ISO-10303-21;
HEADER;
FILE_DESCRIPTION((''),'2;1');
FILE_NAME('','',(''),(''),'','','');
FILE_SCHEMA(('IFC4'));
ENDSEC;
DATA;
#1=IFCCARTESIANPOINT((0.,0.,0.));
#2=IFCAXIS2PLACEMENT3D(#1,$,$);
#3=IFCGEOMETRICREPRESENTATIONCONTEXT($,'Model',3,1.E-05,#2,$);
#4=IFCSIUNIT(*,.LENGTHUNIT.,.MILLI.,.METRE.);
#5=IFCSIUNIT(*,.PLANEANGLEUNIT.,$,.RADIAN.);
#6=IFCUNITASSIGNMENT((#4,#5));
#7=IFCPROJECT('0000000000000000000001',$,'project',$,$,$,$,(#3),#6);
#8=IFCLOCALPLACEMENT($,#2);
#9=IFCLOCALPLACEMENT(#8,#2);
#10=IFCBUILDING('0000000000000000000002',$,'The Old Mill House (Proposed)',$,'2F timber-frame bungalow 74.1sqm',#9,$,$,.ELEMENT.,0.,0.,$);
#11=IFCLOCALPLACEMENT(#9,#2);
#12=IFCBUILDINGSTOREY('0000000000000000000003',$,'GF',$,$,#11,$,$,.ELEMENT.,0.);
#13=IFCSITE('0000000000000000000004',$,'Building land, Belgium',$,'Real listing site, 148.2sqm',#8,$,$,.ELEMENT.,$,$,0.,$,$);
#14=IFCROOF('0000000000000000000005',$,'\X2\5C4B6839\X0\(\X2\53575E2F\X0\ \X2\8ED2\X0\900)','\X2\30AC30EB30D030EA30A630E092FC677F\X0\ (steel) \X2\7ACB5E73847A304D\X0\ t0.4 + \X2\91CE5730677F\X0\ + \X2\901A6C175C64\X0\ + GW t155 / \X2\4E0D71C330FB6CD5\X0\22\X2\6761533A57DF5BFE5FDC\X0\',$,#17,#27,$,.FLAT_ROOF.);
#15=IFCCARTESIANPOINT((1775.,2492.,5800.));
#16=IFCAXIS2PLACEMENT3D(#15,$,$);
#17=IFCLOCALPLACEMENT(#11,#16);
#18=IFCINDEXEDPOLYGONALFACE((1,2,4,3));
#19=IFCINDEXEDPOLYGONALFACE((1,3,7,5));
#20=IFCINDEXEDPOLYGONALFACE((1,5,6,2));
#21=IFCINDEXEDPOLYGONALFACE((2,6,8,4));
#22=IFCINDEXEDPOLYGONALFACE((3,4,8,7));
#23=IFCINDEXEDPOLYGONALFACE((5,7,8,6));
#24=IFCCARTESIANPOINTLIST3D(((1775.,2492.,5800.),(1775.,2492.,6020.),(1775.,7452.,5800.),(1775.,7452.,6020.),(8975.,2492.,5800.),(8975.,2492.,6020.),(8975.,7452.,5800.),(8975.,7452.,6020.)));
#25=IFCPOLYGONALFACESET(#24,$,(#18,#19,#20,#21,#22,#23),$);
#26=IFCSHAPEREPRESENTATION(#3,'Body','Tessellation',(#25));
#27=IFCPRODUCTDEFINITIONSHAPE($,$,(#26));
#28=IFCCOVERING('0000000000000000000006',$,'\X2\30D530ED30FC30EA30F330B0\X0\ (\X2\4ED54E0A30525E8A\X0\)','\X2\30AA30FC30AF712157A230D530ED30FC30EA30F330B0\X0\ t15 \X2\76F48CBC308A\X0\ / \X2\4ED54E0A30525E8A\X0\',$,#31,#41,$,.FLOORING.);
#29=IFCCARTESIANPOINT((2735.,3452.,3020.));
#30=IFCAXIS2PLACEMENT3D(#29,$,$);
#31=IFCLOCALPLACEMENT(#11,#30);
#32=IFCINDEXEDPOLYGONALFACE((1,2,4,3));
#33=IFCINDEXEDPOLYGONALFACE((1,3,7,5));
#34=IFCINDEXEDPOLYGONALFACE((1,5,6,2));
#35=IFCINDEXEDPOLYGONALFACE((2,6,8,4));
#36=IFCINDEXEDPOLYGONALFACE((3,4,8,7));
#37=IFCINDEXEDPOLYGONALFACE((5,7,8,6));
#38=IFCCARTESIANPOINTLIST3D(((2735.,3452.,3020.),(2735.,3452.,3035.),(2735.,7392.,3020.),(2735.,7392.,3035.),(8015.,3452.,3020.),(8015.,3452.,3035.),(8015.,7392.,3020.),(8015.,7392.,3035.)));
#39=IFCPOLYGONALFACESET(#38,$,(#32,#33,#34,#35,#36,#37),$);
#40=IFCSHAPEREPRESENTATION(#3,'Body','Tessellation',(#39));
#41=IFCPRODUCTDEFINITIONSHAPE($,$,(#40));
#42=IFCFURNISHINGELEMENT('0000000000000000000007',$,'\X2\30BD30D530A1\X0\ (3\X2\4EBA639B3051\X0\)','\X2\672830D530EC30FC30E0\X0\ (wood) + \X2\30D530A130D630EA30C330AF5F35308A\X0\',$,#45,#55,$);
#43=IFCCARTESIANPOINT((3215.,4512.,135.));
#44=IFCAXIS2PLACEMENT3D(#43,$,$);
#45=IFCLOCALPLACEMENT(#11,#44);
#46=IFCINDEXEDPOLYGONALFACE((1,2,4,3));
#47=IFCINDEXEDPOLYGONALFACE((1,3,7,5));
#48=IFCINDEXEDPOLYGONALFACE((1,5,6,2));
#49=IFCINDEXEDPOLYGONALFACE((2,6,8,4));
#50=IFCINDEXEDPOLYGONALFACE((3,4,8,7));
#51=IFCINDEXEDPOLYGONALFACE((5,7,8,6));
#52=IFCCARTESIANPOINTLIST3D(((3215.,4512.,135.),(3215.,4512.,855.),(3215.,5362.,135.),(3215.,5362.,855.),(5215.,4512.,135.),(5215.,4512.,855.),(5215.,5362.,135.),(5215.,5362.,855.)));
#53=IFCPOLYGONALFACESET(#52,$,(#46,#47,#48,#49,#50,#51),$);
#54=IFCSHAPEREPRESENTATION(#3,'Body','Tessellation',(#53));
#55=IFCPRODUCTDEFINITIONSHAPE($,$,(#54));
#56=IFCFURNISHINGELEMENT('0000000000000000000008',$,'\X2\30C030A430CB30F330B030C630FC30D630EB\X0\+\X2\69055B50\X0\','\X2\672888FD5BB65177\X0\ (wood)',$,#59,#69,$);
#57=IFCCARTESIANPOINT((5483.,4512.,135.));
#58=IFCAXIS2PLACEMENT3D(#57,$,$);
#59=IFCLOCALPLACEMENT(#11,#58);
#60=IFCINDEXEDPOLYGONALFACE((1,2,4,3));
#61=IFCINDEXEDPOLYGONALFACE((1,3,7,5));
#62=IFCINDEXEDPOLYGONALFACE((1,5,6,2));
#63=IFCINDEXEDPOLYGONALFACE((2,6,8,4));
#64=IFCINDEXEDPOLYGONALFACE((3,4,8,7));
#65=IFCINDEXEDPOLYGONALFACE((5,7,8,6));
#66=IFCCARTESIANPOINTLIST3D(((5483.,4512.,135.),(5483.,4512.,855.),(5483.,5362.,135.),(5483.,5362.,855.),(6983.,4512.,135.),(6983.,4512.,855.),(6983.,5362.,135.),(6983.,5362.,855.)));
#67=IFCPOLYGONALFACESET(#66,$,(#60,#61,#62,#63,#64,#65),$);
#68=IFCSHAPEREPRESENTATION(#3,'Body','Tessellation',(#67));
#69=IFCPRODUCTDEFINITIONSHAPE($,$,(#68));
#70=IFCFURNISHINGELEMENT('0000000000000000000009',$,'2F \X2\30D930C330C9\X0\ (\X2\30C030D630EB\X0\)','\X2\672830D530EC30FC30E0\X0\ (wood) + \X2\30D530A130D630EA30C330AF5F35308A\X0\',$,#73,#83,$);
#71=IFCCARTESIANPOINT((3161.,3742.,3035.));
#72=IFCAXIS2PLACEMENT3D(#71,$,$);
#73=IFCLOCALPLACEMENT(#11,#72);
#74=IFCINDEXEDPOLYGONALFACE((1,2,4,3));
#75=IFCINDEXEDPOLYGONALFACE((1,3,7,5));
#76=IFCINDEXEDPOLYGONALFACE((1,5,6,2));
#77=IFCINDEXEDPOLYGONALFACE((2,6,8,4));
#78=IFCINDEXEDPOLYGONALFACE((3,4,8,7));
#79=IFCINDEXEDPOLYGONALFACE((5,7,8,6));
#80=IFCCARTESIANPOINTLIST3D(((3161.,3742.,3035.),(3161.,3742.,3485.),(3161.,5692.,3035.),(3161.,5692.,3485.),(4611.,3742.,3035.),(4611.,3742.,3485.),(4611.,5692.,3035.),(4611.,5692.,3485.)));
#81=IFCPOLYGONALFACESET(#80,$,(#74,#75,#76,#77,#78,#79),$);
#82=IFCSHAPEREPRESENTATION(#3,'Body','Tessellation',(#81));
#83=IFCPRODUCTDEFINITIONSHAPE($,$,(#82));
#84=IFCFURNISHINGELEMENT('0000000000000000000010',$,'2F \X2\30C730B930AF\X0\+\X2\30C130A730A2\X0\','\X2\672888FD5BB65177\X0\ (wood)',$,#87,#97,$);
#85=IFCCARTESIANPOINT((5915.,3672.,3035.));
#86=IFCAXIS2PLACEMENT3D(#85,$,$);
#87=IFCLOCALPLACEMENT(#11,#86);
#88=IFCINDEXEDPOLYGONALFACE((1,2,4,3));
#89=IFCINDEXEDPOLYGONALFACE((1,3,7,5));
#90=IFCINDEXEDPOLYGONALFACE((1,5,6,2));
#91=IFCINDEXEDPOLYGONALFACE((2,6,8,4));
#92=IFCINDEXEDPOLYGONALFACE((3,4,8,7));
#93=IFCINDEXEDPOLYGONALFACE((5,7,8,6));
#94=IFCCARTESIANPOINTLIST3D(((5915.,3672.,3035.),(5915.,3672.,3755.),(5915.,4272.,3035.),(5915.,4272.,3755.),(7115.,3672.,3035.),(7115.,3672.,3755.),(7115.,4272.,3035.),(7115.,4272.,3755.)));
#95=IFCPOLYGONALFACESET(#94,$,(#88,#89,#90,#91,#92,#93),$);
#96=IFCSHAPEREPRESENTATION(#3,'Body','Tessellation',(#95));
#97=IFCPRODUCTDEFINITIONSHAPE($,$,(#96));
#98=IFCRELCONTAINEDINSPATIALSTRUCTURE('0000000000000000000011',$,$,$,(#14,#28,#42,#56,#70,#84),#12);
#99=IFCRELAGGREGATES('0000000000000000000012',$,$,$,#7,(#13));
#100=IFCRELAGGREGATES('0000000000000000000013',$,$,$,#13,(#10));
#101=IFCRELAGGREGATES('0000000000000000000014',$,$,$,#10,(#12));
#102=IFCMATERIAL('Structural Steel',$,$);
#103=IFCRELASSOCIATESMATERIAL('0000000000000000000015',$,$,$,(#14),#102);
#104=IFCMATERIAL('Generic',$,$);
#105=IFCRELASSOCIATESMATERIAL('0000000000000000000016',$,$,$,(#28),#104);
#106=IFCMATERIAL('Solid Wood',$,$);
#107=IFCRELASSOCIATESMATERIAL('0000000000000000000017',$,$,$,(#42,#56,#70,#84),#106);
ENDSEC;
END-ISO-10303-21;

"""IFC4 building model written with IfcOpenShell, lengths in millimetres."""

from ifc_helpers import new_model, si_unit, frame, frame_2d, origin, place, context, project, spatial, rectangle, extrude, material, element, save


model = new_model("IFC4")

# Units and contexts
model_context = context("Model", 3, precision=1e-05, world=origin())
ifc_project = project(units=[si_unit("LENGTHUNIT", "METRE", prefix="MILLI"), si_unit("PLANEANGLEUNIT", "RADIAN")], contexts=[model_context])

# Site, building, storey
site_placement = place(None, origin())
site = spatial("IfcSite", under=ifc_project, at=site_placement, Name="Building land, Belgium", ObjectType="Real listing site, 148.2sqm", CompositionType="ELEMENT", RefElevation=0.0)
building_placement = place(site_placement, origin())
building = spatial("IfcBuilding", under=site, at=building_placement, Name="The Old Mill House (Proposed)", ObjectType="2F timber-frame bungalow 74.1sqm", CompositionType="ELEMENT", ElevationOfRefHeight=0.0, ElevationOfTerrain=0.0)
storey_placement = place(building_placement, origin())
storey = spatial("IfcBuildingStorey", under=building, at=storey_placement, Name="GF", CompositionType="ELEMENT", Elevation=0.0)

# Shared definitions
ifc_material_1 = material(Name="Solid Wood")

# Roof
ifc_material_2 = material(Name="Structural Steel")
for number, where, name in (
    (1, (1775.0, 2492.0, 5800.0), "屋根(南帯 軒900)"),
):
    element("IfcRoof", number, at=place(storey_placement, frame(where)), inside=storey, material=ifc_material_2, Name=name, Description="ガルバリウム鋼板 (steel) 立平葺き t0.4 + 野地板 + 通気層 + GW t155 / 不燃・法22条区域対応", PredefinedType="FLAT_ROOF", context=model_context, shape_type="SweptSolid", body=[
        extrude(rectangle(XDim=7200.0, YDim=4960.0, at=frame_2d((3600.0, 2480.0))), frame((1775.0, 2492.0, 5800.0)), (0.0, 0.0, 1.0), 220.0),
    ])

# Covering
ifc_material_3 = material(Name="Generic")
covering_placement = place(storey_placement, frame((2735.0, 3452.0, 3020.0)))
element("IfcCovering", 2, at=covering_placement, inside=storey, material=ifc_material_3, Name="フローリング (仕上げ床)", Description="オーク無垢フローリング t15 直貼り / 仕上げ床", PredefinedType="FLOORING", context=model_context, shape_type="SweptSolid", body=[
    extrude(rectangle(XDim=5280.0, YDim=3940.0, at=frame_2d((2640.0, 1970.0))), frame((2735.0, 3452.0, 3020.0)), (0.0, 0.0, 1.0), 15.0),
])

# Furnishing elements
furnishing_1_placement = place(storey_placement, frame((3215.0, 4512.0, 135.0)))
element("IfcFurnishingElement", 3, at=furnishing_1_placement, inside=storey, material=ifc_material_1, Name="ソファ (3人掛け)", Description="木フレーム (wood) + ファブリック張り", context=model_context, shape_type="SweptSolid", body=[
    extrude(rectangle(XDim=2000.0, YDim=850.0, at=frame_2d((1000.0, 425.0))), frame((3215.0, 4512.0, 135.0)), (0.0, 0.0, 1.0), 720.0),
])
furnishing_2_placement = place(storey_placement, frame((5483.0, 4512.0, 135.0)))
element("IfcFurnishingElement", 4, at=furnishing_2_placement, inside=storey, material=ifc_material_1, Name="ダイニングテーブル+椅子", Description="木製家具 (wood)", context=model_context, shape_type="SweptSolid", body=[
    extrude(rectangle(XDim=1500.0, YDim=850.0, at=frame_2d((750.0, 425.0))), frame((5483.0, 4512.0, 135.0)), (0.0, 0.0, 1.0), 720.0),
])
furnishing_3_placement = place(storey_placement, frame((3161.0, 3742.0, 3035.0)))
element("IfcFurnishingElement", 5, at=furnishing_3_placement, inside=storey, material=ifc_material_1, Name="2F ベッド (ダブル)", Description="木フレーム (wood) + ファブリック張り", context=model_context, shape_type="SweptSolid", body=[
    extrude(rectangle(XDim=1450.0, YDim=1950.0, at=frame_2d((725.0, 975.0))), frame((3161.0, 3742.0, 3035.0)), (0.0, 0.0, 1.0), 450.0),
])
furnishing_4_placement = place(storey_placement, frame((5915.0, 3672.0, 3035.0)))
element("IfcFurnishingElement", 6, at=furnishing_4_placement, inside=storey, material=ifc_material_1, Name="2F デスク+チェア", Description="木製家具 (wood)", context=model_context, shape_type="SweptSolid", body=[
    extrude(rectangle(XDim=1200.0, YDim=600.0, at=frame_2d((600.0, 300.0))), frame((5915.0, 3672.0, 3035.0)), (0.0, 0.0, 1.0), 720.0),
])

save(model, "model.ifc")
